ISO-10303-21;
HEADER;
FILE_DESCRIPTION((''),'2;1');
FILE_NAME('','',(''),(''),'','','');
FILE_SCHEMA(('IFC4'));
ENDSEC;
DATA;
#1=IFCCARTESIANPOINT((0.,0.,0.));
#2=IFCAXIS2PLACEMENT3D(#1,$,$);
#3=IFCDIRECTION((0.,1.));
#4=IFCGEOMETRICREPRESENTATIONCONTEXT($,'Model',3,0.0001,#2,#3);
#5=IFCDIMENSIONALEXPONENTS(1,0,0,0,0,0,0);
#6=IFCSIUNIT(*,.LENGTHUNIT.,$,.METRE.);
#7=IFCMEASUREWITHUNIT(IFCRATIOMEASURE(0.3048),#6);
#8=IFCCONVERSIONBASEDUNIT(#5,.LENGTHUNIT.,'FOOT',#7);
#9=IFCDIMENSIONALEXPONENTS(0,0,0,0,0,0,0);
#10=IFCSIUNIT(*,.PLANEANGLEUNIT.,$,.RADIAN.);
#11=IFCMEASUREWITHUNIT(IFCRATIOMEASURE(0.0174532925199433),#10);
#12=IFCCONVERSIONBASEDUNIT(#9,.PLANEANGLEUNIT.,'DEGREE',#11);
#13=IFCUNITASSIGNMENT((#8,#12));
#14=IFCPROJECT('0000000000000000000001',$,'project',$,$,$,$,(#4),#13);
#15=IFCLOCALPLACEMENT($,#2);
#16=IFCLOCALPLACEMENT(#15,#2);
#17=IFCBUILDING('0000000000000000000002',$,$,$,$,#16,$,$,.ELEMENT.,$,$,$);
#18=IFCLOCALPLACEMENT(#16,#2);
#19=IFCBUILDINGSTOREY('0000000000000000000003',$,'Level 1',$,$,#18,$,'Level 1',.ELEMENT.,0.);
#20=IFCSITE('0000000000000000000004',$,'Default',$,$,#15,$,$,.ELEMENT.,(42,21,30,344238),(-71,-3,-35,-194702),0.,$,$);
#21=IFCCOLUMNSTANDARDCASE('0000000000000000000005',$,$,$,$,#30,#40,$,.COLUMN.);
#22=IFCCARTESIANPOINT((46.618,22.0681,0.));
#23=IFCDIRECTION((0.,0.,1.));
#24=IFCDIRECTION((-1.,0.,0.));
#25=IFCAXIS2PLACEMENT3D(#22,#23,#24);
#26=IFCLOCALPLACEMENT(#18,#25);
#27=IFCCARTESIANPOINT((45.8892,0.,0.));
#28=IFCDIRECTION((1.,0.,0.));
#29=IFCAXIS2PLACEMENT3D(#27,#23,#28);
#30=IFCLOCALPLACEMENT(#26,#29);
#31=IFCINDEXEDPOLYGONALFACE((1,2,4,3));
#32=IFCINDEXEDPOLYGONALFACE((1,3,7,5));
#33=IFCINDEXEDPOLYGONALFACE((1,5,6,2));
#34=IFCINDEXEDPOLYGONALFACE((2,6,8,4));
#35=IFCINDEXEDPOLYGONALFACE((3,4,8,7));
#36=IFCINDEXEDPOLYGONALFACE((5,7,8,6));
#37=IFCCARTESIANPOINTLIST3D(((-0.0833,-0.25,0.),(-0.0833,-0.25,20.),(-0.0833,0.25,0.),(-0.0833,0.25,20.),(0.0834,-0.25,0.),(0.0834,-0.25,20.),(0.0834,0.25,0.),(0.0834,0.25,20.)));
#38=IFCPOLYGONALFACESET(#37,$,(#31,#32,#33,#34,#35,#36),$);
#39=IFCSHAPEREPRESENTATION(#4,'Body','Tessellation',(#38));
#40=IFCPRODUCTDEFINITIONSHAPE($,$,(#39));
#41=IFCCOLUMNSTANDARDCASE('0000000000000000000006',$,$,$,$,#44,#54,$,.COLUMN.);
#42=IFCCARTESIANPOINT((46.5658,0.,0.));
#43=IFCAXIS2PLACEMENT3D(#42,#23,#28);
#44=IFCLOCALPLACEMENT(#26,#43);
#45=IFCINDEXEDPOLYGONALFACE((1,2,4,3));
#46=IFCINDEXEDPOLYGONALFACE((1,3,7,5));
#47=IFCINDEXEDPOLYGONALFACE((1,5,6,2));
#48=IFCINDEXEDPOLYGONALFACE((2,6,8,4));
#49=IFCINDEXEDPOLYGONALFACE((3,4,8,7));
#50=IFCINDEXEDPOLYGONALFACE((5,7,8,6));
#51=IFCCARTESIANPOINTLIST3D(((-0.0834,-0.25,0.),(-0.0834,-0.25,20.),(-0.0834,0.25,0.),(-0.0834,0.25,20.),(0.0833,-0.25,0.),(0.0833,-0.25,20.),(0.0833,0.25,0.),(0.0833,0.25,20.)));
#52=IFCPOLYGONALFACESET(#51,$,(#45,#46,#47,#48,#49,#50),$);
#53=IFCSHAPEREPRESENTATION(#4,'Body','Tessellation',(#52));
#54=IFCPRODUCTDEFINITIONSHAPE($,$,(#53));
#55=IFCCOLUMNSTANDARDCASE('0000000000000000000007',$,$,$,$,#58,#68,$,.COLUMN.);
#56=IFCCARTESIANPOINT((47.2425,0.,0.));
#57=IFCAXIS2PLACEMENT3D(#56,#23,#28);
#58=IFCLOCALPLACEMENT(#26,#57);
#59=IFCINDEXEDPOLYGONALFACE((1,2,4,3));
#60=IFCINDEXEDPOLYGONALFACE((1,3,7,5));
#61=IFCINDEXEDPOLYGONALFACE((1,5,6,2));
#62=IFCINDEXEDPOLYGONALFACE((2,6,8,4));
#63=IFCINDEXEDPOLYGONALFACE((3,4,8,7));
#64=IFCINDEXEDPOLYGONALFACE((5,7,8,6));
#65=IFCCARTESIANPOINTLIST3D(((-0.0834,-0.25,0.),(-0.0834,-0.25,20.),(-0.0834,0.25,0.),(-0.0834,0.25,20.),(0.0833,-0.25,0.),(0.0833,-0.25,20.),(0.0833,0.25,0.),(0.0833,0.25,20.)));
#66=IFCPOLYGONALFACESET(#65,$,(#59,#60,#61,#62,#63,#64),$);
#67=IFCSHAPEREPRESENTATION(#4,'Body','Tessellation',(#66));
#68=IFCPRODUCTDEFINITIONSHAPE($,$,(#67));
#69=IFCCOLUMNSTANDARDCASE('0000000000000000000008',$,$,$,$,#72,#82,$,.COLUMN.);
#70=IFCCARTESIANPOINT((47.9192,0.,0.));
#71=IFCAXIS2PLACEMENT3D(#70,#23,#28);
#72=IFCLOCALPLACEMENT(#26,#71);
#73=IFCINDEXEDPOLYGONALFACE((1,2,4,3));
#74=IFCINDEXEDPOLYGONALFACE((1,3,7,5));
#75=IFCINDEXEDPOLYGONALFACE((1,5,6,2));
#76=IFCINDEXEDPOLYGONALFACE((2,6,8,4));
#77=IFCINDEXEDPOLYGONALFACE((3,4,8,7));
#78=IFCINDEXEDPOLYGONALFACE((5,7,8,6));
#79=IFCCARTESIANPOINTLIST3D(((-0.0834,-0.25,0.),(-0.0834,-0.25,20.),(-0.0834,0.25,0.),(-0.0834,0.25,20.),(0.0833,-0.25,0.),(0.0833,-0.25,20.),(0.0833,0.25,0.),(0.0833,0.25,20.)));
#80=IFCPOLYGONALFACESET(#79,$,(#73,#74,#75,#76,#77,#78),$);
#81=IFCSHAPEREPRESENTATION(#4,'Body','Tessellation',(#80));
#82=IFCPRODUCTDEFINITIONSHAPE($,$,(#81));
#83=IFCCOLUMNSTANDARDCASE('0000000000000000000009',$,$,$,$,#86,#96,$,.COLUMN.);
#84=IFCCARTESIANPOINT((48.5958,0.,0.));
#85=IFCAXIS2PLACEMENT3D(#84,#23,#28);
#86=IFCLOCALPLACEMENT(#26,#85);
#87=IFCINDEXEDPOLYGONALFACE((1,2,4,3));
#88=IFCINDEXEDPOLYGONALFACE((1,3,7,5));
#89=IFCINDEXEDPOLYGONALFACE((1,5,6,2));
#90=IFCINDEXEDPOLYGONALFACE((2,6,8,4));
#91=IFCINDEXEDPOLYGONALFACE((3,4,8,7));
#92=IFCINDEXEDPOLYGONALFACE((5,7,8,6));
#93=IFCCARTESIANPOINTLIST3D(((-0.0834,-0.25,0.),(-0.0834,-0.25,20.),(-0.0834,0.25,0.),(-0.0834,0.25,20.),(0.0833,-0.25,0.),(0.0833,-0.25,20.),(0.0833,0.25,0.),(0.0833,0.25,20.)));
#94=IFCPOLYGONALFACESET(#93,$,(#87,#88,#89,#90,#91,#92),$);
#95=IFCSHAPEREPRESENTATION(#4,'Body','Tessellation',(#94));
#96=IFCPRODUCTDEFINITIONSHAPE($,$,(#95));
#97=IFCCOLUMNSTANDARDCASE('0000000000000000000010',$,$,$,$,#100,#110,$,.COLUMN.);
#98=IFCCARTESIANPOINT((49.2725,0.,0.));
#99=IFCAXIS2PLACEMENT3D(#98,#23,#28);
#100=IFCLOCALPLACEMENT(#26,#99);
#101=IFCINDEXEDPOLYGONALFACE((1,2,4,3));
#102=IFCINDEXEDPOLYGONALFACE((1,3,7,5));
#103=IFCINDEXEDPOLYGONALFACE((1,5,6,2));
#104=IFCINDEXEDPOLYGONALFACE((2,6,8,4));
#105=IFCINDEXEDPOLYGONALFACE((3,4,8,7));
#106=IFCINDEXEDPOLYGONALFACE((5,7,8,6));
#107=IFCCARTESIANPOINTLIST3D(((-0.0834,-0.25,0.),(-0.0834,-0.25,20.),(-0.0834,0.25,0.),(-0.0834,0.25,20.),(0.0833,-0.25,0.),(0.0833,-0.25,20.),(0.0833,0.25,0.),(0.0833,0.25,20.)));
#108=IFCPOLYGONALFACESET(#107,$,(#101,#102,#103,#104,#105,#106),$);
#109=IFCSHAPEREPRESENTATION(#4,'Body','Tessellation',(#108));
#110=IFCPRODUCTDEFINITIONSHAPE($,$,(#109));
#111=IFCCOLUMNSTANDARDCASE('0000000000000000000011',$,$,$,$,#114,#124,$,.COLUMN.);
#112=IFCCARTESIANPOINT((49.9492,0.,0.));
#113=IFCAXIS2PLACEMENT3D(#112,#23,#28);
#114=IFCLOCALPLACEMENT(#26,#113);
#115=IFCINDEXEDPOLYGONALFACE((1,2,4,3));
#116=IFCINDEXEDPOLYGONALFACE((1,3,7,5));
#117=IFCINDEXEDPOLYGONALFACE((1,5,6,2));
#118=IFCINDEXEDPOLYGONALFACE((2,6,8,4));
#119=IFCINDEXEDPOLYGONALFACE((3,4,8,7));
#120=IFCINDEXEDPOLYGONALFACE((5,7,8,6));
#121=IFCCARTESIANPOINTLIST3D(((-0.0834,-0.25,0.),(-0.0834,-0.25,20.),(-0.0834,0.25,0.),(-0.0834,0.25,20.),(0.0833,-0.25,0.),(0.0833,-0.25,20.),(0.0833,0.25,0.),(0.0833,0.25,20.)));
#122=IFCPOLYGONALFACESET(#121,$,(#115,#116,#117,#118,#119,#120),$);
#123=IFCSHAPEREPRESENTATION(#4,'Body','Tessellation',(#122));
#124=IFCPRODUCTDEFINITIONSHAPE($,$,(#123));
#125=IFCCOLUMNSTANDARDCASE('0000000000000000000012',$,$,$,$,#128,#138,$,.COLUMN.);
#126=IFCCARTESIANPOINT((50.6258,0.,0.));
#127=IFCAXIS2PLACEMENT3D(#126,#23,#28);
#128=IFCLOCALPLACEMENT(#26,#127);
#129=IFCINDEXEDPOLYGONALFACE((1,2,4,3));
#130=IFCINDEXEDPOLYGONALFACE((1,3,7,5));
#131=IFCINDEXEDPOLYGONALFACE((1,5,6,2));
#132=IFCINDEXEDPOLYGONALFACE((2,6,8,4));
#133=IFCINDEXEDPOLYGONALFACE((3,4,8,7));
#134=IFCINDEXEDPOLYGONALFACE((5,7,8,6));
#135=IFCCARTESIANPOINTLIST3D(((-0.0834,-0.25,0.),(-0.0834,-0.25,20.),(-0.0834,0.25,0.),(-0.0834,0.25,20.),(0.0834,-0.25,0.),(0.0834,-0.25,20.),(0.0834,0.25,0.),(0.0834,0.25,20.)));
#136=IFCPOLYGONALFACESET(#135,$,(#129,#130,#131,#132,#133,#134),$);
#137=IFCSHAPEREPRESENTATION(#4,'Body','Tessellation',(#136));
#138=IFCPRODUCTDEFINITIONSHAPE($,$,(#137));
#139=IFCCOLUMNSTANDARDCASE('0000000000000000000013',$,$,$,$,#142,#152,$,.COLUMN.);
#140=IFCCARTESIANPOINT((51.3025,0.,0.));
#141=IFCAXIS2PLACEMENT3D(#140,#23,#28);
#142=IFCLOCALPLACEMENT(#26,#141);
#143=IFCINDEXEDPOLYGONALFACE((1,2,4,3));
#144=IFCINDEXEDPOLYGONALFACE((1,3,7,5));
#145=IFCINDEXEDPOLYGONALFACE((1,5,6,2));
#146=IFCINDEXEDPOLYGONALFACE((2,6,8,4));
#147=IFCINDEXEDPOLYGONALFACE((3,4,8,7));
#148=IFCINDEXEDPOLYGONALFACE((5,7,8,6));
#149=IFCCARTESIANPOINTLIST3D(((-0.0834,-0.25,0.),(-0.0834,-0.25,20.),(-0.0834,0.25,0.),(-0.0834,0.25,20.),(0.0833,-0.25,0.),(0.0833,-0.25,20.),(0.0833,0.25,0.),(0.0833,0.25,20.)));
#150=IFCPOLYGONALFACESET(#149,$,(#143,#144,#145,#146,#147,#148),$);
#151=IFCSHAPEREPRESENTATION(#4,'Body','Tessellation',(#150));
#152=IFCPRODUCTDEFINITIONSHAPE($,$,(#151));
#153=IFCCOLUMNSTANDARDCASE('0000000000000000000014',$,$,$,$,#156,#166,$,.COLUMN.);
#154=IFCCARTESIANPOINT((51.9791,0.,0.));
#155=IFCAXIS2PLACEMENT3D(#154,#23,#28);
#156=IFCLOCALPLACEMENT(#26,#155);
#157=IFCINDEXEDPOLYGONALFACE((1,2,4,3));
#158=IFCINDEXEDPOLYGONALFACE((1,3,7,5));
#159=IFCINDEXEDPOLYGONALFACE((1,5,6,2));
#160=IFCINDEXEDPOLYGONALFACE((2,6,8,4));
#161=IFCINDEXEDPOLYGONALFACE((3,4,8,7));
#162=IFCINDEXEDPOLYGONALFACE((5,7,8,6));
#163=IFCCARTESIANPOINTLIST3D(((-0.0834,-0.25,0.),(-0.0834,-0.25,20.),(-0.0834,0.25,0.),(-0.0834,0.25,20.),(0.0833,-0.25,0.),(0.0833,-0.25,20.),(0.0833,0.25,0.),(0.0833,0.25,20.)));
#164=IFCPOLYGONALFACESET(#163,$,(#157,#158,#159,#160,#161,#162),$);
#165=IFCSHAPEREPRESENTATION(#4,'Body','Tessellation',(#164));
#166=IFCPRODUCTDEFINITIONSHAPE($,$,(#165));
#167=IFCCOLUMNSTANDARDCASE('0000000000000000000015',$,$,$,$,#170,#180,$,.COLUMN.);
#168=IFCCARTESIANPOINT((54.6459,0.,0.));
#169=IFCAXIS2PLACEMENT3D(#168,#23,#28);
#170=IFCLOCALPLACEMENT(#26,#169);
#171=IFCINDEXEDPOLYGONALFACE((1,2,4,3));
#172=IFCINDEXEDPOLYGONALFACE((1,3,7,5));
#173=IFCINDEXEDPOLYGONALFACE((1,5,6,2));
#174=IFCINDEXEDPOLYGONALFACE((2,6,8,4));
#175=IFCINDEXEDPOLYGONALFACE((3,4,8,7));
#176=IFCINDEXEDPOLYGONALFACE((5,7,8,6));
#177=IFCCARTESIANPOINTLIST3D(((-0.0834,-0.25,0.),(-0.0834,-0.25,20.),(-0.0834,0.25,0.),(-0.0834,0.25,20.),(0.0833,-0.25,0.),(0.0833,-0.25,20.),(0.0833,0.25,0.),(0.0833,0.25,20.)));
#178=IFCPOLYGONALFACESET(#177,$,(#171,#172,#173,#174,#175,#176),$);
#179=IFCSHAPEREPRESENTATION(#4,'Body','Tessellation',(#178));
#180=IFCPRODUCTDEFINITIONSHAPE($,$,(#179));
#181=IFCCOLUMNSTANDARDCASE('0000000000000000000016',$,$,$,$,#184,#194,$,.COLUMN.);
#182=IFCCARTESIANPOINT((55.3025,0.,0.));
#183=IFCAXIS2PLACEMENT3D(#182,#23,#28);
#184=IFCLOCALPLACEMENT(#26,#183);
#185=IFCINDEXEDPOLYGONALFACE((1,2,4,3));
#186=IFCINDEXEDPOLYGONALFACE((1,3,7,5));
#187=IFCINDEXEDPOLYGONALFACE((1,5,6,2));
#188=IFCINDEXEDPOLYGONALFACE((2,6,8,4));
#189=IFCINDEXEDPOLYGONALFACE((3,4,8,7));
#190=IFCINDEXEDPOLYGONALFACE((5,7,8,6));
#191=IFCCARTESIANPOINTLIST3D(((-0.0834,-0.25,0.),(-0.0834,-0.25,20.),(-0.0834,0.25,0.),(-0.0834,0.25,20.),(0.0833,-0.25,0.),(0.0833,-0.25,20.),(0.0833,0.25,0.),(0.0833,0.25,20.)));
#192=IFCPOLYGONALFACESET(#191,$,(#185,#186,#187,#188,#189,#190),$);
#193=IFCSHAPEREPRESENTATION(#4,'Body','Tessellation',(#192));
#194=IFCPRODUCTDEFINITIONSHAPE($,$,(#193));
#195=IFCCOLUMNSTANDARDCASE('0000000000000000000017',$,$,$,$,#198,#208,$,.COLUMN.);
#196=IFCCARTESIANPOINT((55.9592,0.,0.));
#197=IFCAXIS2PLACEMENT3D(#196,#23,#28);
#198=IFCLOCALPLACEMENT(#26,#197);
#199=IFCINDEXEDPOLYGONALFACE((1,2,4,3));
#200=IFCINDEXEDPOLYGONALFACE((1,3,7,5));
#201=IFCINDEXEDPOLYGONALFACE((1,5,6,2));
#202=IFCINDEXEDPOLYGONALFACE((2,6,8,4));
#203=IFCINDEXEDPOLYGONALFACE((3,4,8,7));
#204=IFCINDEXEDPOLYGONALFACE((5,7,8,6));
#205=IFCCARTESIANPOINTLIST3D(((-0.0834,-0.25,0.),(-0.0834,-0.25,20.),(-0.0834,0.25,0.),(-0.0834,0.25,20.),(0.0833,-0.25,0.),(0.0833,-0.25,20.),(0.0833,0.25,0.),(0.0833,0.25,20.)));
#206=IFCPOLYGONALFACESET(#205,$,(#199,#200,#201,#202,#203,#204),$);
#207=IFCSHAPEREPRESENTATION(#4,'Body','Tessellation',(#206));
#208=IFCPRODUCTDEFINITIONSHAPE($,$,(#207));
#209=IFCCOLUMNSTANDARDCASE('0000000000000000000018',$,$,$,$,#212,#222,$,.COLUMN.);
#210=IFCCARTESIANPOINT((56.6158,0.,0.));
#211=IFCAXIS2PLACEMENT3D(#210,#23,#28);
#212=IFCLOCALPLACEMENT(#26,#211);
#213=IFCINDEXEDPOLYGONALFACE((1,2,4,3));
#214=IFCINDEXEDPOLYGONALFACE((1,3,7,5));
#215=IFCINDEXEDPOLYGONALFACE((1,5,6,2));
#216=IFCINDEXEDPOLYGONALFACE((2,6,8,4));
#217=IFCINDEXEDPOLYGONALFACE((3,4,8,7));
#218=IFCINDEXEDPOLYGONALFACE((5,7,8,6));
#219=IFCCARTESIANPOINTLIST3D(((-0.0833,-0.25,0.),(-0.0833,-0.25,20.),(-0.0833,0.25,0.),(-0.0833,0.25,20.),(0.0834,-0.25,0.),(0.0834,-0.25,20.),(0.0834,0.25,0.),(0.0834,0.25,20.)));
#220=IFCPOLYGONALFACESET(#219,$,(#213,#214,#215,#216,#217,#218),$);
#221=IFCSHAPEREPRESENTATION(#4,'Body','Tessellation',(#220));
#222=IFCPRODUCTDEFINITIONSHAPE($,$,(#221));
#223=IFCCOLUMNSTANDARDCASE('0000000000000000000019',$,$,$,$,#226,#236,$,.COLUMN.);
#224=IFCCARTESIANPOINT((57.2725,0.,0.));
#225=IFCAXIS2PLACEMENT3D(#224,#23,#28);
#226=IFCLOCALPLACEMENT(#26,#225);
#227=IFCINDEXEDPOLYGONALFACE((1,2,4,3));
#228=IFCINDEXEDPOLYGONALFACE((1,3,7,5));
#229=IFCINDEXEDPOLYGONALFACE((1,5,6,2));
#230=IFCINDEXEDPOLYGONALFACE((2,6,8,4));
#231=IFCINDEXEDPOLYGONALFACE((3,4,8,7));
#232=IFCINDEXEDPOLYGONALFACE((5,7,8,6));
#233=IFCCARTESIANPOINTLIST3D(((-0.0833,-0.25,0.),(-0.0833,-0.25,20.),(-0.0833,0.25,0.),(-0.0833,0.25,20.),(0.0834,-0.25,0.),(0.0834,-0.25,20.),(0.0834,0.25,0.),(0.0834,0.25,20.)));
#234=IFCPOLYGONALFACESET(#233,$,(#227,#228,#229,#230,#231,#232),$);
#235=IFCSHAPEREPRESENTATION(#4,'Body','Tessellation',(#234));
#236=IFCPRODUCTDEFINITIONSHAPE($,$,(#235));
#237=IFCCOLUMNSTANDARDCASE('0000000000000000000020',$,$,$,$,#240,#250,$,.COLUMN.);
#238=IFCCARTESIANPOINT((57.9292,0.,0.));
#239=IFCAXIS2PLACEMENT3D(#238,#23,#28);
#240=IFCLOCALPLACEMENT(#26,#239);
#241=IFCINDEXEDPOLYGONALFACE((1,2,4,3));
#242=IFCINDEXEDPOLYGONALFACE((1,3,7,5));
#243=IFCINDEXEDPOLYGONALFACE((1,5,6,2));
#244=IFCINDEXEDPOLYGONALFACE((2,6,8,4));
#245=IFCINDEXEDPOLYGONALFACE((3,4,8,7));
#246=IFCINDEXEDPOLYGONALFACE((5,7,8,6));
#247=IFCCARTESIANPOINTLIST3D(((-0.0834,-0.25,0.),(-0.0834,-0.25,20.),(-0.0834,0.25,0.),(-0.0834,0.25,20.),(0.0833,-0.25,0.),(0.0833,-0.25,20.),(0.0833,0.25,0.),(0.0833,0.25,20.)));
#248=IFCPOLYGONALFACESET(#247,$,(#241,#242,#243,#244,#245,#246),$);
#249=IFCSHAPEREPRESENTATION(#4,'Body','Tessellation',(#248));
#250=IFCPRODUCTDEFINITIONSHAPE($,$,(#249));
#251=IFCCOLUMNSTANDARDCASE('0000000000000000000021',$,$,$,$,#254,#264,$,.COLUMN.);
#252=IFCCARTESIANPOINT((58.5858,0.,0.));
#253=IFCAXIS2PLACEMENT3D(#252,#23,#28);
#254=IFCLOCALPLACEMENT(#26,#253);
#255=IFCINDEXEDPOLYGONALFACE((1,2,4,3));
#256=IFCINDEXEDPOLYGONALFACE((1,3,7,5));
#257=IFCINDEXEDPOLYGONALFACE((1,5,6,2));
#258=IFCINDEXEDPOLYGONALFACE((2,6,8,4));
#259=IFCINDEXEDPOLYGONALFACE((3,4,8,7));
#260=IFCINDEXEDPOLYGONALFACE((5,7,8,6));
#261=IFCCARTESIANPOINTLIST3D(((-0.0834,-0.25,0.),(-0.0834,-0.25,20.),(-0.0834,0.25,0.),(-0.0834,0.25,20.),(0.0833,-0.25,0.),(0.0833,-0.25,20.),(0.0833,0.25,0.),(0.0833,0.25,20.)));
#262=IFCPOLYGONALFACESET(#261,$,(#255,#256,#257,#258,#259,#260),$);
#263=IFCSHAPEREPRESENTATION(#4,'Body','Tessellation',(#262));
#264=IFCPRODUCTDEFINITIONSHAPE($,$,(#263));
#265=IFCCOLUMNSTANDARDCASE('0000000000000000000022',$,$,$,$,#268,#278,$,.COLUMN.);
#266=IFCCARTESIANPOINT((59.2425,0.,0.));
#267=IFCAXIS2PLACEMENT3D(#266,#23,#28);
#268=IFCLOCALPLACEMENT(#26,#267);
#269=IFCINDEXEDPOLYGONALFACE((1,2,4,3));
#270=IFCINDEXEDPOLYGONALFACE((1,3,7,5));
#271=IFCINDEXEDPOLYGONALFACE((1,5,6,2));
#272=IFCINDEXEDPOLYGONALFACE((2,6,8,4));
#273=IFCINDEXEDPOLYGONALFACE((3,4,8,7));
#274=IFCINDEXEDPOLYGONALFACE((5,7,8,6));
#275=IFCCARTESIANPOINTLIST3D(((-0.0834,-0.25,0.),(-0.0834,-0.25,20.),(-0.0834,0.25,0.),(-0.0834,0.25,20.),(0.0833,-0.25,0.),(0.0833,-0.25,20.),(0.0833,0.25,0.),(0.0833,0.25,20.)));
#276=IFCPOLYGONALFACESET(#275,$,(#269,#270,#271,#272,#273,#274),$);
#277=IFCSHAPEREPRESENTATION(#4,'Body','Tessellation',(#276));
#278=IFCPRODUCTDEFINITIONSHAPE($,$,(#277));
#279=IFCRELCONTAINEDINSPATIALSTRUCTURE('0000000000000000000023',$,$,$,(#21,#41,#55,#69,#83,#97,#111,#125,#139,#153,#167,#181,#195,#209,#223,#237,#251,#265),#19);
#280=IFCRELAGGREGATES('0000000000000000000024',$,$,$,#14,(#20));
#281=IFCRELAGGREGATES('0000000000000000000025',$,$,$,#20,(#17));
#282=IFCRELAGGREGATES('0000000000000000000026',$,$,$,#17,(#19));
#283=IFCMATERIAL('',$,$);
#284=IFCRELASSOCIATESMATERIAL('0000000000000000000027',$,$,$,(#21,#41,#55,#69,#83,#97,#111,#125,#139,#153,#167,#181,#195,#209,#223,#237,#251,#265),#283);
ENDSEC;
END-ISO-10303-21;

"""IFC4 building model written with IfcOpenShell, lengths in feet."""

from ifc_helpers import new_model, entity, si_unit, converted_unit, direction, frame, origin, place, context, project, spatial, rectangle, extrude, material, element, save


model = new_model("IFC4")

# Units and contexts
model_context = context("Model", 3, precision=0.0001, world=origin(), true_north=direction((0.0, 1.0)))
ifc_project = project(units=[converted_unit("LENGTHUNIT", "FOOT", entity("IfcRatioMeasure", 0.3048), si_unit("LENGTHUNIT", "METRE"), dimensions=[1, 0, 0, 0, 0, 0, 0]), converted_unit("PLANEANGLEUNIT", "DEGREE", entity("IfcRatioMeasure", 0.0174532925199433), si_unit("PLANEANGLEUNIT", "RADIAN"), dimensions=[0, 0, 0, 0, 0, 0, 0])], contexts=[model_context])

# Site, building, storey
site_placement = place(None, origin())
site = spatial("IfcSite", under=ifc_project, at=site_placement, Name="Default", CompositionType="ELEMENT", RefLatitude=(42, 21, 30, 344238), RefLongitude=(-71, -3, -35, -194702), RefElevation=0.0)
building_placement = place(site_placement, origin())
building = spatial("IfcBuilding", under=site, at=building_placement, CompositionType="ELEMENT")
storey_placement = place(building_placement, origin())
storey = spatial("IfcBuildingStorey", under=building, at=storey_placement, Name="Level 1", LongName="Level 1", CompositionType="ELEMENT", Elevation=0.0)

# Columns
ifc_material_1 = material(Name="")
placement = place(storey_placement, frame((46.618, 22.0681, 0.0), z_axis=(0.0, 0.0, 1.0), x_axis=(-1.0, 0.0, 0.0)))
for number, where, z_axis, x_axis in (
    (1, (45.8892, 0.0, 0.0), (0.0, 0.0, 1.0), (1.0, 0.0, 0.0)),
    (2, (46.5658, 0.0, 0.0), (0.0, 0.0, 1.0), (1.0, 0.0, 0.0)),
    (3, (47.2425, 0.0, 0.0), (0.0, 0.0, 1.0), (1.0, 0.0, 0.0)),
    (4, (47.9192, 0.0, 0.0), (0.0, 0.0, 1.0), (1.0, 0.0, 0.0)),
    (5, (48.5958, 0.0, 0.0), (0.0, 0.0, 1.0), (1.0, 0.0, 0.0)),
    (6, (49.2725, 0.0, 0.0), (0.0, 0.0, 1.0), (1.0, 0.0, 0.0)),
    (7, (49.9492, 0.0, 0.0), (0.0, 0.0, 1.0), (1.0, 0.0, 0.0)),
    (8, (50.6258, 0.0, 0.0), (0.0, 0.0, 1.0), (1.0, 0.0, 0.0)),
    (9, (51.3025, 0.0, 0.0), (0.0, 0.0, 1.0), (1.0, 0.0, 0.0)),
    (10, (51.9791, 0.0, 0.0), (0.0, 0.0, 1.0), (1.0, 0.0, 0.0)),
    (11, (54.6459, 0.0, 0.0), (0.0, 0.0, 1.0), (1.0, 0.0, 0.0)),
    (12, (55.3025, 0.0, 0.0), (0.0, 0.0, 1.0), (1.0, 0.0, 0.0)),
    (13, (55.9592, 0.0, 0.0), (0.0, 0.0, 1.0), (1.0, 0.0, 0.0)),
    (14, (56.6158, 0.0, 0.0), (0.0, 0.0, 1.0), (1.0, 0.0, 0.0)),
    (15, (57.2725, 0.0, 0.0), (0.0, 0.0, 1.0), (1.0, 0.0, 0.0)),
    (16, (57.9292, 0.0, 0.0), (0.0, 0.0, 1.0), (1.0, 0.0, 0.0)),
    (17, (58.5858, 0.0, 0.0), (0.0, 0.0, 1.0), (1.0, 0.0, 0.0)),
    (18, (59.2425, 0.0, 0.0), (0.0, 0.0, 1.0), (1.0, 0.0, 0.0)),
):
    element("IfcColumnStandardCase", number, at=place(placement, frame(where, z_axis=z_axis, x_axis=x_axis)), inside=storey, material=ifc_material_1, PredefinedType="COLUMN", context=model_context, shape_type="SweptSolid", body=[
        extrude(rectangle(XDim=0.1667, YDim=0.5), origin(), (0.0, 0.0, 1.0), 20.0),
    ])

save(model, "model.ifc")
